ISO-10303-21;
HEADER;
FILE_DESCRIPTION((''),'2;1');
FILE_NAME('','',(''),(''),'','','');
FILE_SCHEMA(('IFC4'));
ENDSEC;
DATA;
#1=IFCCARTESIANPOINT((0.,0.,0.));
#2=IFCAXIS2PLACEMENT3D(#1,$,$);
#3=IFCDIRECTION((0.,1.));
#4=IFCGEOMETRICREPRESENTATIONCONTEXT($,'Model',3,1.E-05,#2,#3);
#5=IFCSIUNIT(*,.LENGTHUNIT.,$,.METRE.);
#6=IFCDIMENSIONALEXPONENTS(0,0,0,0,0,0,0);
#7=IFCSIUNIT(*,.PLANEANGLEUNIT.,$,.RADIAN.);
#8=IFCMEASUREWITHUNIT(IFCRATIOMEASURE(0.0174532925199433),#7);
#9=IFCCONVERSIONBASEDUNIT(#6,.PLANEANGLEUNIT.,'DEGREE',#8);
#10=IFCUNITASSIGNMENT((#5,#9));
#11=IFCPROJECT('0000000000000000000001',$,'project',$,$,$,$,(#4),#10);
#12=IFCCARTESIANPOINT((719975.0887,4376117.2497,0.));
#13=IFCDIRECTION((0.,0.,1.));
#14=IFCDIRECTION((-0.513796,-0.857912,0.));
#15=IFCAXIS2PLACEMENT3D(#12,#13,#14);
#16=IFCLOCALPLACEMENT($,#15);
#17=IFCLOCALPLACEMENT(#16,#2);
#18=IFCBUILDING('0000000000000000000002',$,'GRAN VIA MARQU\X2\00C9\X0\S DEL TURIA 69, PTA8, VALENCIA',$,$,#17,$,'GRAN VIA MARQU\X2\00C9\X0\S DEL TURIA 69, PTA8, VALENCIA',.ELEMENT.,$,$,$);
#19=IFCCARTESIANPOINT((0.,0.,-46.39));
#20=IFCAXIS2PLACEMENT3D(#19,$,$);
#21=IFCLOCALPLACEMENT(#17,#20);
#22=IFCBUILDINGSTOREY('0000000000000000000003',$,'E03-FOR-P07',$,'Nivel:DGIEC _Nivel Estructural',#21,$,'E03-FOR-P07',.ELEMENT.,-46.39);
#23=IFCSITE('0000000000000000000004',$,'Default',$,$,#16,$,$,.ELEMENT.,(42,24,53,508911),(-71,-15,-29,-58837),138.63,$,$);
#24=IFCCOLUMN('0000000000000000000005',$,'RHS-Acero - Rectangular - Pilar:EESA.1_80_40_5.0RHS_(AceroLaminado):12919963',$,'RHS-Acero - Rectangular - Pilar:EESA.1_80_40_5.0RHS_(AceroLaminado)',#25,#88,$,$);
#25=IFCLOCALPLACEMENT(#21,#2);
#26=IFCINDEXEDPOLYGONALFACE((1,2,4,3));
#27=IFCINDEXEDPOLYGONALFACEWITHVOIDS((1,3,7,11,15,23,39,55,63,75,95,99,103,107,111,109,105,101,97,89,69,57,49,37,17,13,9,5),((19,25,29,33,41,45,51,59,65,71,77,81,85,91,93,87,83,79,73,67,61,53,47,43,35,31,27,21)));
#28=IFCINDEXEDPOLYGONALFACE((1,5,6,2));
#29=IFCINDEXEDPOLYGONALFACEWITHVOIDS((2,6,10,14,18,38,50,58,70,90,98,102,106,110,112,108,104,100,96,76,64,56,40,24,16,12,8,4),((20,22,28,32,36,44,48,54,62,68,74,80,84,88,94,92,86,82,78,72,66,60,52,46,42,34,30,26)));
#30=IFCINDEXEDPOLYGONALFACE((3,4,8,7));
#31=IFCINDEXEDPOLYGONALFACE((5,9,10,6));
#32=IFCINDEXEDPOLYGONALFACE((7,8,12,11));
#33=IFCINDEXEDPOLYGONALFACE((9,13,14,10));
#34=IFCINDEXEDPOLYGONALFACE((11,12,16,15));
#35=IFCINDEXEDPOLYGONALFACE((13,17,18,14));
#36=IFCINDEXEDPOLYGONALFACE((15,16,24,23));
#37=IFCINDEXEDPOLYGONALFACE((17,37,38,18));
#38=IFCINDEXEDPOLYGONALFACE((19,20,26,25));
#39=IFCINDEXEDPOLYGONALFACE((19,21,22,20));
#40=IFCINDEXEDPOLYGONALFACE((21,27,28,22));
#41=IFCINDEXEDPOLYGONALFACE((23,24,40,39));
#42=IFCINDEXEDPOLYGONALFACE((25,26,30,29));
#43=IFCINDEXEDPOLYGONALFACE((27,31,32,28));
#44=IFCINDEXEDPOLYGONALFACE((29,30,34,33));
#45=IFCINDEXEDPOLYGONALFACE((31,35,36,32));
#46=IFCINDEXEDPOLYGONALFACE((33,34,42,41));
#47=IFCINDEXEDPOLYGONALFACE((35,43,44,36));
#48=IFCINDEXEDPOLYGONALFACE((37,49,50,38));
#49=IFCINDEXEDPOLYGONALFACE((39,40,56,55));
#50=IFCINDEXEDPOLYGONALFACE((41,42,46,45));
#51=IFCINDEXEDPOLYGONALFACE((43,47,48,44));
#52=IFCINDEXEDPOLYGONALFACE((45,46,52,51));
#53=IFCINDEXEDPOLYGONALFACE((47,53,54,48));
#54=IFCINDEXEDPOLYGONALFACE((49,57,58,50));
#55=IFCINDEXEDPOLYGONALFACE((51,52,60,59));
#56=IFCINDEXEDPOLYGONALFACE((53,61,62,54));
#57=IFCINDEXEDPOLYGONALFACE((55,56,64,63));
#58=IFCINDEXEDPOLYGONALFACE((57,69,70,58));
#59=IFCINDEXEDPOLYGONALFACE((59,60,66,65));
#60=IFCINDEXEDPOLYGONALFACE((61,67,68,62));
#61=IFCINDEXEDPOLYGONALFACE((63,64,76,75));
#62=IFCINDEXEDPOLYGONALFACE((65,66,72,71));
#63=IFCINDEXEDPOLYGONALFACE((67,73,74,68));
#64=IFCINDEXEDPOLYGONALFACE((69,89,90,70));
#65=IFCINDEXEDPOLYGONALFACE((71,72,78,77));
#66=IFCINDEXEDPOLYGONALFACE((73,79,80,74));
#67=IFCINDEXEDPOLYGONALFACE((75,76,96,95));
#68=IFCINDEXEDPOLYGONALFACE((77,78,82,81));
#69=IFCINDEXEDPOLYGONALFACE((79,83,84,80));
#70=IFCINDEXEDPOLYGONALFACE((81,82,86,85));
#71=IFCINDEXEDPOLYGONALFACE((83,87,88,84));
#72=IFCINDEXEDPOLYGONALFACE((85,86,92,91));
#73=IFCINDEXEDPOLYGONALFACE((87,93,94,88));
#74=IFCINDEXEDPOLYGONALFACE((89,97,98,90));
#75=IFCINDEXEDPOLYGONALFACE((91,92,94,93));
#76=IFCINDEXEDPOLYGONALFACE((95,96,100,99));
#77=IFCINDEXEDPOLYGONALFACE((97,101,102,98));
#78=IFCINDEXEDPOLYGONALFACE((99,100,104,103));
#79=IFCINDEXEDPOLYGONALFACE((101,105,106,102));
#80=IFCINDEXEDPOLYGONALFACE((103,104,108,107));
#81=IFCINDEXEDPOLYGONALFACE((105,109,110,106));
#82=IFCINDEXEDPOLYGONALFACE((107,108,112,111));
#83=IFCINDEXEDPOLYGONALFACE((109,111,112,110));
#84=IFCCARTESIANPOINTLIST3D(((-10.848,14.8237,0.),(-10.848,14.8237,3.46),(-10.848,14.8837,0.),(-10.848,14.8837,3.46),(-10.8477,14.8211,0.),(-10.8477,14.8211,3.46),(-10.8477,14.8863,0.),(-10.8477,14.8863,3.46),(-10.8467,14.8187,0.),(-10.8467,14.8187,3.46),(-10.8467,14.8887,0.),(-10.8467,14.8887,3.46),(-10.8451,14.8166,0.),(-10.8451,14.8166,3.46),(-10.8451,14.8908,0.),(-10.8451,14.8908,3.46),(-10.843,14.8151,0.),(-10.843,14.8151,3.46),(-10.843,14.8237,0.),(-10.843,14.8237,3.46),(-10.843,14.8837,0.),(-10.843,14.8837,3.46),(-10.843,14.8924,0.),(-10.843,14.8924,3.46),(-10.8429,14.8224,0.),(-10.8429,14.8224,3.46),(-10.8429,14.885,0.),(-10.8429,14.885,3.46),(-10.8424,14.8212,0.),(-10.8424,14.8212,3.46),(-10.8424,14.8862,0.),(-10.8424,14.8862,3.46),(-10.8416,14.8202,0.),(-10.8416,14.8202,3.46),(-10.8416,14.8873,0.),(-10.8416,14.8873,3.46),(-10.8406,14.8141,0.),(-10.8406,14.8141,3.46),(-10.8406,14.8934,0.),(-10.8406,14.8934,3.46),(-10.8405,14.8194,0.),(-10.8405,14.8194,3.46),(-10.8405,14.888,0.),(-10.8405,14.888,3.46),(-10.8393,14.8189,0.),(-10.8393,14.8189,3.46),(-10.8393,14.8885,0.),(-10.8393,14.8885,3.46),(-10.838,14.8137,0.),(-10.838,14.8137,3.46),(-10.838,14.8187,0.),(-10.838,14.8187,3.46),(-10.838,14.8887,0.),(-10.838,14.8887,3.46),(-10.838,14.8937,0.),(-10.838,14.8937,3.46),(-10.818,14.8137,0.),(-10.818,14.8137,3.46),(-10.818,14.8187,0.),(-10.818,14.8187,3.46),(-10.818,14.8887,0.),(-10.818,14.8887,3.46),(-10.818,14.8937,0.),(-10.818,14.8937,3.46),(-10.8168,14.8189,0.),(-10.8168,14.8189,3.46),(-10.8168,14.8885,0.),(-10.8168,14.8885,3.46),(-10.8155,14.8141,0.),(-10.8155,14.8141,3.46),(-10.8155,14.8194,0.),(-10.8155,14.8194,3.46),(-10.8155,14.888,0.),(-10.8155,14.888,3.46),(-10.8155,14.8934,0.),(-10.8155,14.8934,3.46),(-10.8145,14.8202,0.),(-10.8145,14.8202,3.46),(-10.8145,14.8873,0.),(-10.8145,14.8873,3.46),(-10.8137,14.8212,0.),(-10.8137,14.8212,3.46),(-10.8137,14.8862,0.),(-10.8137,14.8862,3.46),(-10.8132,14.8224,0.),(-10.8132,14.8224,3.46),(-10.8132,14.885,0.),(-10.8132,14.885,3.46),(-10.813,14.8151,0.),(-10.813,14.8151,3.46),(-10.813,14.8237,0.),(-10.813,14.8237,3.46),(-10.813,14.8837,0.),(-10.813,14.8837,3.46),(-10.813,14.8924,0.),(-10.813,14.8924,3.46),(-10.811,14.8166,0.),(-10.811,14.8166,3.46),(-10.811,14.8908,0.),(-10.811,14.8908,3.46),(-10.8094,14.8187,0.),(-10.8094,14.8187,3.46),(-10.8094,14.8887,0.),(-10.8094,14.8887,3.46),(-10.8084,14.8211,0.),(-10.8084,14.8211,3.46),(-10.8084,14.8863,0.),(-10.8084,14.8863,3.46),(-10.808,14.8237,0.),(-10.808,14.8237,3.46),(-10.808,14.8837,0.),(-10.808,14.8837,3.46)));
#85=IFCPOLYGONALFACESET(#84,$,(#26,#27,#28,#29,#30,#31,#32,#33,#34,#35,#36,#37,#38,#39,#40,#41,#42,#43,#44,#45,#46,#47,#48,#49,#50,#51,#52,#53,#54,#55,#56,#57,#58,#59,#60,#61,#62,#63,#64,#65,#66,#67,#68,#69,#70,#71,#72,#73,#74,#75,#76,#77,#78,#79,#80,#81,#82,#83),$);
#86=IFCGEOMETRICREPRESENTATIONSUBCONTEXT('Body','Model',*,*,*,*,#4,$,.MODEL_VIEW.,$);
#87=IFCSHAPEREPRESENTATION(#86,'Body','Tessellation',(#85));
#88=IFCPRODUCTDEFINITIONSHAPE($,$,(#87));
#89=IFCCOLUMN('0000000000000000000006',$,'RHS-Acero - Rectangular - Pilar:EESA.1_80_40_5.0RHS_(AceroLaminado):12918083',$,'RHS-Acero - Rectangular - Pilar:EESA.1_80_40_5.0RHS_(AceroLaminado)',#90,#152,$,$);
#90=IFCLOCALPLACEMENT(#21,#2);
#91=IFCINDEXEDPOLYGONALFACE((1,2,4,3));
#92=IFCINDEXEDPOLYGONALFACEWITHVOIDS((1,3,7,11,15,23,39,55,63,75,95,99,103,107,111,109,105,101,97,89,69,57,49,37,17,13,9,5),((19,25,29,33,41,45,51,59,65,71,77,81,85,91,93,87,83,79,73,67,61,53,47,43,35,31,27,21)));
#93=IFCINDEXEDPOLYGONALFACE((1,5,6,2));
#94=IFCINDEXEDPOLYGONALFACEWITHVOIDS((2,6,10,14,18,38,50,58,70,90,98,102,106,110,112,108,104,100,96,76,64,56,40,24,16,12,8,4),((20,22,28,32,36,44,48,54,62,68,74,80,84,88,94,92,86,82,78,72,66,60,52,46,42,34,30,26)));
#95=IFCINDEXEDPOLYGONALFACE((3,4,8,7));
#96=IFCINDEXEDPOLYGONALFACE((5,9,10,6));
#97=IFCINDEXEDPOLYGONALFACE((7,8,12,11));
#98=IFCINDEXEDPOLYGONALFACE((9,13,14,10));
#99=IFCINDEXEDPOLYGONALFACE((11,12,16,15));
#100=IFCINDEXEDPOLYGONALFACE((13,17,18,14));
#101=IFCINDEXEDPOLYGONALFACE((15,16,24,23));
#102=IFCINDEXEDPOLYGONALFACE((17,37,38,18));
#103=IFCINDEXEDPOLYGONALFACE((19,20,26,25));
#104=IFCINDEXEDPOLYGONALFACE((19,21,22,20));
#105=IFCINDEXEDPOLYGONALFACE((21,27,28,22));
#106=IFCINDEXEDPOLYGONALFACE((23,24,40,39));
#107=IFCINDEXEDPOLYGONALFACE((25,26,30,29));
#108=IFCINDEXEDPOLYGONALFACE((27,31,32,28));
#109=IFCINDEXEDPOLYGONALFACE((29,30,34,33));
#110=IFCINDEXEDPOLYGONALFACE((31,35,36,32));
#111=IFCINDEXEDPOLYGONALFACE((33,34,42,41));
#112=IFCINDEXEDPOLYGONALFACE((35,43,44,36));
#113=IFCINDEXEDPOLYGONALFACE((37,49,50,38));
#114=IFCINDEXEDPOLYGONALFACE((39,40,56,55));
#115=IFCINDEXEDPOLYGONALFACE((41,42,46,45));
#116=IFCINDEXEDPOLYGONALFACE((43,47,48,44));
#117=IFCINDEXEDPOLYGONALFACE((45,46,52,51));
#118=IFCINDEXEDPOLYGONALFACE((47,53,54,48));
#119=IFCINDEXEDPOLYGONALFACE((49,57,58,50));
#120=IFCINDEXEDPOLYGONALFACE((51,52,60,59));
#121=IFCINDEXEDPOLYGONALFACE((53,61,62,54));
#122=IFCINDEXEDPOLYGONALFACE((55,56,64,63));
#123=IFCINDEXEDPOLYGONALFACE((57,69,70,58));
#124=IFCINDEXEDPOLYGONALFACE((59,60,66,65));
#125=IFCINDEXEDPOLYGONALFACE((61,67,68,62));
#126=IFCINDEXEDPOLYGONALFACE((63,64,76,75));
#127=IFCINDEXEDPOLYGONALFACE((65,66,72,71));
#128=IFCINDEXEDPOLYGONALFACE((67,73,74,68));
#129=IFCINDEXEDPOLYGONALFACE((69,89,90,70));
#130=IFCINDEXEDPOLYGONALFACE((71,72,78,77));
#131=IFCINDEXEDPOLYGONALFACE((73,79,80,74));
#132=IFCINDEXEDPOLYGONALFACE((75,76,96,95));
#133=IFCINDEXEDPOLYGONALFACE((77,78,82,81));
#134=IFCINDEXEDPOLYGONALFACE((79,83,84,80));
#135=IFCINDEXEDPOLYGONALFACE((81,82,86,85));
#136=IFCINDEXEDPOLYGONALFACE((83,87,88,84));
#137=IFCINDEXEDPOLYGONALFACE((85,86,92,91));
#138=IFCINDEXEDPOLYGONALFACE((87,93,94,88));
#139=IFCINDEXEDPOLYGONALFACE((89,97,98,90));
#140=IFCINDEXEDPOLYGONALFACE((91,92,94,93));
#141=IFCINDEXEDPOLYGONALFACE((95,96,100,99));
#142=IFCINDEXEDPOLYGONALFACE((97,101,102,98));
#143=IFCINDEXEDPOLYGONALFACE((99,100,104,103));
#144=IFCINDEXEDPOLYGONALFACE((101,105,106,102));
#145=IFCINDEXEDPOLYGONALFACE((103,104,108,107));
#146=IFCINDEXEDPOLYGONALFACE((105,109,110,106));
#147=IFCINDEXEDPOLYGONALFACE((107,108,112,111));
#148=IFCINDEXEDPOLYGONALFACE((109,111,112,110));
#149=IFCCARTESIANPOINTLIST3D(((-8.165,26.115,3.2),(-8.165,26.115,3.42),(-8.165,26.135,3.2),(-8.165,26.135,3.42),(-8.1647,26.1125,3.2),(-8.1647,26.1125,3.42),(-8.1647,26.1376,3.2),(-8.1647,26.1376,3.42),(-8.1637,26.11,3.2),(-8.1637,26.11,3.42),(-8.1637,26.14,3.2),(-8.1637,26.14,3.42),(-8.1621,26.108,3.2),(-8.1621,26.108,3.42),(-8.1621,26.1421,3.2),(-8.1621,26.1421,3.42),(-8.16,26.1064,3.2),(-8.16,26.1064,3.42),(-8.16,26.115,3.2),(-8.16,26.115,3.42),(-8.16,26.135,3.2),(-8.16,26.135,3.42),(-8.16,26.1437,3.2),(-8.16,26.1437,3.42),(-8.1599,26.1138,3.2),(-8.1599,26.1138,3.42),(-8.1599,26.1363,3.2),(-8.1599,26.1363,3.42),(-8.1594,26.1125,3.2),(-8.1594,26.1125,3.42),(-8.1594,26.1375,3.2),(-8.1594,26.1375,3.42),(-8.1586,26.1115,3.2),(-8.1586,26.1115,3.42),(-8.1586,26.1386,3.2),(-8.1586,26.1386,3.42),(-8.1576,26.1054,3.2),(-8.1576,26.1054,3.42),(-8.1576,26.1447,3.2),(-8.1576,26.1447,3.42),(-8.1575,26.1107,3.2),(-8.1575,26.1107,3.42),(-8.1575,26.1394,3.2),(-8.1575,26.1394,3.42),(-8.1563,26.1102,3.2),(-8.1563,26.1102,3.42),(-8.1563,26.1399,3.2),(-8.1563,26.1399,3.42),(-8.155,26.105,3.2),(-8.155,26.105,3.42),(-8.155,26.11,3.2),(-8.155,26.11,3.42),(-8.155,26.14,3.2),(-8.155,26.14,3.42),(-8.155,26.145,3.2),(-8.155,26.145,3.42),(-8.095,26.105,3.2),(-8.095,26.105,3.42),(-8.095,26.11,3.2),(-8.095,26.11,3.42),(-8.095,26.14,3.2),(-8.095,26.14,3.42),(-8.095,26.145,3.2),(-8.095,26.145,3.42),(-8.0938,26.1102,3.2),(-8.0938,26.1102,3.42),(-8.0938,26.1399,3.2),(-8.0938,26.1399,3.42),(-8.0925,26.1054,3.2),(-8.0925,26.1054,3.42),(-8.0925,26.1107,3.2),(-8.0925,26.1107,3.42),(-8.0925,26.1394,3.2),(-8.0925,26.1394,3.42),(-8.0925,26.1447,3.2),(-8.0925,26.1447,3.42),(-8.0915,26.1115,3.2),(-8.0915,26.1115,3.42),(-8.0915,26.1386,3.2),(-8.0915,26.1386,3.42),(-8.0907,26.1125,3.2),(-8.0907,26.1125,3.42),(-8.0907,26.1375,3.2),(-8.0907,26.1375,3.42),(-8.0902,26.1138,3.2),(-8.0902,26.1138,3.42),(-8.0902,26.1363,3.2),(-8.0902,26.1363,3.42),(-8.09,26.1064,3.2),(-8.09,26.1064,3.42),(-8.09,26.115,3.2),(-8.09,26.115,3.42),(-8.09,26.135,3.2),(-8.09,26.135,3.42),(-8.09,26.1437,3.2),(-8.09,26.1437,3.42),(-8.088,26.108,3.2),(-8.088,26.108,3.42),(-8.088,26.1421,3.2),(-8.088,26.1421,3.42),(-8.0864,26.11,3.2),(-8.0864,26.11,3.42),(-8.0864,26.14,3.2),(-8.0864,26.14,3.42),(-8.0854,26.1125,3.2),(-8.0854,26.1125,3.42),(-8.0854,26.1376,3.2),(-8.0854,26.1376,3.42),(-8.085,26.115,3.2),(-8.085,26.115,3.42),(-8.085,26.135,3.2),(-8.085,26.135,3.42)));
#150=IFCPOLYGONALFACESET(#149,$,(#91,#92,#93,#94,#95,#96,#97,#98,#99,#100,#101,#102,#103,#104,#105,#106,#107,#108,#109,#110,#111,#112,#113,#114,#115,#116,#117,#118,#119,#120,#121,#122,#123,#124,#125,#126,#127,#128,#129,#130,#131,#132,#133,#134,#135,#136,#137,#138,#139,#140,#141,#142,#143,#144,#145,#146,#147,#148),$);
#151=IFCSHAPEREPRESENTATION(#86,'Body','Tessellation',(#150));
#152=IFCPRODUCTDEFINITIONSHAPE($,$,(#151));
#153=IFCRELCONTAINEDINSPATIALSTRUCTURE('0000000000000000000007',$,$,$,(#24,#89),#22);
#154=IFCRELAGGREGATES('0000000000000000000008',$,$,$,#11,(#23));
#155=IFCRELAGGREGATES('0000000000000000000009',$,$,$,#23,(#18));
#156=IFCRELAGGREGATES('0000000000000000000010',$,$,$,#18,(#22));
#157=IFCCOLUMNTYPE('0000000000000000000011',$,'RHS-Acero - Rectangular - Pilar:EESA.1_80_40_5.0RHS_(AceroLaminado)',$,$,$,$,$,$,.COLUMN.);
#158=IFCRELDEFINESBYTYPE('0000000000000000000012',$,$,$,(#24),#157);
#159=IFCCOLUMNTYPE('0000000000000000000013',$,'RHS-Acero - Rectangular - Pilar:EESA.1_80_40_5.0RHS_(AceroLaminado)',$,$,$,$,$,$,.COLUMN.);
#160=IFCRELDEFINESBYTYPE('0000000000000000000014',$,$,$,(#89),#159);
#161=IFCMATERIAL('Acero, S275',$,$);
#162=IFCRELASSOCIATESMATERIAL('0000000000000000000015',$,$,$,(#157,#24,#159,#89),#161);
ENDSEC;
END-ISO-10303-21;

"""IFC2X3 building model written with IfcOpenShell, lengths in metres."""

from ifc_helpers import new_model, entity, si_unit, converted_unit, direction, frame, frame_2d, origin, place, context, subcontext, project, spatial, polyline, circle_curve, parameter, trimmed, segment, composite_curve, outline, extrude, source, transform, mapped, material, type_object, type_shapes, element, save


model = new_model("IFC2X3")

# Units and contexts
model_context = context("Model", 3, precision=1e-05, world=origin(), true_north=direction((0.0, 1.0)))
body_context = subcontext(model_context, "Body", "Model", "MODEL_VIEW")
ifc_project = project(units=[si_unit("LENGTHUNIT", "METRE"), converted_unit("PLANEANGLEUNIT", "DEGREE", entity("IfcRatioMeasure", 0.0174532925199433), si_unit("PLANEANGLEUNIT", "RADIAN"), dimensions=[0, 0, 0, 0, 0, 0, 0])], contexts=[model_context])

# Site, building, storey
site_placement = place(None, frame((719975.0887, 4376117.2497, 0.0), z_axis=(0.0, 0.0, 1.0), x_axis=(-0.513796, -0.857912, 0.0)))
site = spatial("IfcSite", under=ifc_project, at=site_placement, Name="Default", CompositionType="ELEMENT", RefLatitude=(42, 24, 53, 508911), RefLongitude=(-71, -15, -29, -58837), RefElevation=138.63)
building_placement = place(site_placement, origin())
building = spatial("IfcBuilding", under=site, at=building_placement, Name="GRAN VIA MARQUÉS DEL TURIA 69, PTA8, VALENCIA", LongName="GRAN VIA MARQUÉS DEL TURIA 69, PTA8, VALENCIA", CompositionType="ELEMENT")
storey_placement = place(building_placement, frame((0.0, 0.0, -46.39)))
storey = spatial("IfcBuildingStorey", under=building, at=storey_placement, Name="E03-FOR-P07", ObjectType="Nivel:DGIEC _Nivel Estructural", LongName="E03-FOR-P07", CompositionType="ELEMENT", Elevation=-46.39)

# Columns
ifc_material = material(Name="Acero, S275")
column_type_1 = type_object("IfcColumnType", Name="RHS-Acero - Rectangular - Pilar:EESA.1_80_40_5.0RHS_(AceroLaminado)", PredefinedType="COLUMN", material=ifc_material)
shared_shape_1 = source(origin(), body_context, "Body", "SweptSolid", [
    extrude(outline(composite_curve([segment(polyline([(-0.01, -0.04), (0.01, -0.04)]), True, "CONTINUOUS"), segment(trimmed(circle_curve(frame_2d((0.01, -0.03), x_axis=(-1.0, 0.0)), 0.01), [parameter(90.0)], [parameter(180.0)], True, "PARAMETER"), True, "CONTINUOUS"), segment(polyline([(0.02, -0.03), (0.02, 0.03)]), True, "CONTINUOUS"), segment(trimmed(circle_curve(frame_2d((0.01, 0.03), x_axis=(-1.0, 0.0)), 0.01), [parameter(180.0)], [parameter(270.0)], True, "PARAMETER"), True, "CONTINUOUS"), segment(polyline([(0.01, 0.04), (-0.01, 0.04)]), True, "CONTINUOUS"), segment(trimmed(circle_curve(frame_2d((-0.01, 0.03), x_axis=(-1.0, 0.0)), 0.01), [parameter(270.0)], [parameter(360.0)], True, "PARAMETER"), True, "CONTINUOUS"), segment(polyline([(-0.02, 0.03), (-0.02, -0.03)]), True, "CONTINUOUS"), segment(trimmed(circle_curve(frame_2d((-0.01, -0.03), x_axis=(-1.0, 0.0)), 0.01), [parameter(360.0)], [parameter(90.0)], True, "PARAMETER"), True, "CONTINUOUS")], self_intersect=False), holes=[composite_curve([segment(trimmed(circle_curve(frame_2d((-0.01, -0.03), x_axis=(-1.0, 0.0)), 0.005), [parameter(0.0)], [parameter(90.0)], True, "PARAMETER"), False, "CONTINUOUS"), segment(polyline([(-0.015, -0.03), (-0.015, 0.03)]), True, "CONTINUOUS"), segment(trimmed(circle_curve(frame_2d((-0.01, 0.03), x_axis=(-1.0, 0.0)), 0.005), [parameter(270.0)], [parameter(0.0)], True, "PARAMETER"), False, "CONTINUOUS"), segment(polyline([(-0.01, 0.035), (0.01, 0.035)]), True, "CONTINUOUS"), segment(trimmed(circle_curve(frame_2d((0.01, 0.03), x_axis=(-1.0, 0.0)), 0.005), [parameter(180.0)], [parameter(270.0)], True, "PARAMETER"), False, "CONTINUOUS"), segment(polyline([(0.015, 0.03), (0.015, -0.03)]), True, "CONTINUOUS"), segment(trimmed(circle_curve(frame_2d((0.01, -0.03), x_axis=(-1.0, 0.0)), 0.005), [parameter(90.0)], [parameter(180.0)], True, "PARAMETER"), False, "CONTINUOUS"), segment(polyline([(0.01, -0.035), (-0.01, -0.035)]), True, "CONTINUOUS")], self_intersect=False)]), frame((0.0, 0.0, -46.39), z_axis=(0.0, 0.0, 1.0), x_axis=(-1.0, 0.0, 0.0)), (0.0, 0.0, 1.0), 3.46),
])
type_shapes(column_type_1, [shared_shape_1])
column_1_placement = place(storey_placement, frame((-10.828, 14.8537, 46.39)))
element("IfcColumn", 1, at=column_1_placement, inside=storey, type_object=column_type_1, material=ifc_material, Name="RHS-Acero - Rectangular - Pilar:EESA.1_80_40_5.0RHS_(AceroLaminado):12919963", ObjectType="RHS-Acero - Rectangular - Pilar:EESA.1_80_40_5.0RHS_(AceroLaminado)", context=body_context, shape_type="MappedRepresentation", body=[
    mapped(shared_shape_1, transform((0.0, 0.0, 0.0), scale=1.0)),
])
column_type_2 = type_object("IfcColumnType", Name="RHS-Acero - Rectangular - Pilar:EESA.1_80_40_5.0RHS_(AceroLaminado)", PredefinedType="COLUMN", material=ifc_material)
shared_shape_2 = source(origin(), body_context, "Body", "SweptSolid", [
    extrude(outline(composite_curve([segment(polyline([(-0.01, -0.04), (0.01, -0.04)]), True, "CONTINUOUS"), segment(trimmed(circle_curve(frame_2d((0.01, -0.03), x_axis=(-1.0, 0.0)), 0.01), [parameter(90.0)], [parameter(180.0)], True, "PARAMETER"), True, "CONTINUOUS"), segment(polyline([(0.02, -0.03), (0.02, 0.03)]), True, "CONTINUOUS"), segment(trimmed(circle_curve(frame_2d((0.01, 0.03), x_axis=(-1.0, 0.0)), 0.01), [parameter(180.0)], [parameter(270.0)], True, "PARAMETER"), True, "CONTINUOUS"), segment(polyline([(0.01, 0.04), (-0.01, 0.04)]), True, "CONTINUOUS"), segment(trimmed(circle_curve(frame_2d((-0.01, 0.03), x_axis=(-1.0, 0.0)), 0.01), [parameter(270.0)], [parameter(360.0)], True, "PARAMETER"), True, "CONTINUOUS"), segment(polyline([(-0.02, 0.03), (-0.02, -0.03)]), True, "CONTINUOUS"), segment(trimmed(circle_curve(frame_2d((-0.01, -0.03), x_axis=(-1.0, 0.0)), 0.01), [parameter(360.0)], [parameter(90.0)], True, "PARAMETER"), True, "CONTINUOUS")], self_intersect=False), holes=[composite_curve([segment(trimmed(circle_curve(frame_2d((-0.01, -0.03), x_axis=(-1.0, 0.0)), 0.005), [parameter(0.0)], [parameter(90.0)], True, "PARAMETER"), False, "CONTINUOUS"), segment(polyline([(-0.015, -0.03), (-0.015, 0.03)]), True, "CONTINUOUS"), segment(trimmed(circle_curve(frame_2d((-0.01, 0.03), x_axis=(-1.0, 0.0)), 0.005), [parameter(270.0)], [parameter(0.0)], True, "PARAMETER"), False, "CONTINUOUS"), segment(polyline([(-0.01, 0.035), (0.01, 0.035)]), True, "CONTINUOUS"), segment(trimmed(circle_curve(frame_2d((0.01, 0.03), x_axis=(-1.0, 0.0)), 0.005), [parameter(180.0)], [parameter(270.0)], True, "PARAMETER"), False, "CONTINUOUS"), segment(polyline([(0.015, 0.03), (0.015, -0.03)]), True, "CONTINUOUS"), segment(trimmed(circle_curve(frame_2d((0.01, -0.03), x_axis=(-1.0, 0.0)), 0.005), [parameter(90.0)], [parameter(180.0)], True, "PARAMETER"), False, "CONTINUOUS"), segment(polyline([(0.01, -0.035), (-0.01, -0.035)]), True, "CONTINUOUS")], self_intersect=False)]), frame((0.0, 0.0, -43.19), z_axis=(0.0, 0.0, 1.0), x_axis=(-1.0, 0.0, 0.0)), (0.0, 0.0, 1.0), 0.22),
])
type_shapes(column_type_2, [shared_shape_2])
column_2_placement = place(storey_placement, frame((-8.125, 26.125, 46.39), z_axis=(0.0, 0.0, 1.0), x_axis=(0.0, 1.0, 0.0)))
element("IfcColumn", 2, at=column_2_placement, inside=storey, type_object=column_type_2, material=ifc_material, Name="RHS-Acero - Rectangular - Pilar:EESA.1_80_40_5.0RHS_(AceroLaminado):12918083", ObjectType="RHS-Acero - Rectangular - Pilar:EESA.1_80_40_5.0RHS_(AceroLaminado)", context=body_context, shape_type="MappedRepresentation", body=[
    mapped(shared_shape_2, transform((0.0, 0.0, 0.0), scale=1.0)),
])

save(model, "model.ifc")
